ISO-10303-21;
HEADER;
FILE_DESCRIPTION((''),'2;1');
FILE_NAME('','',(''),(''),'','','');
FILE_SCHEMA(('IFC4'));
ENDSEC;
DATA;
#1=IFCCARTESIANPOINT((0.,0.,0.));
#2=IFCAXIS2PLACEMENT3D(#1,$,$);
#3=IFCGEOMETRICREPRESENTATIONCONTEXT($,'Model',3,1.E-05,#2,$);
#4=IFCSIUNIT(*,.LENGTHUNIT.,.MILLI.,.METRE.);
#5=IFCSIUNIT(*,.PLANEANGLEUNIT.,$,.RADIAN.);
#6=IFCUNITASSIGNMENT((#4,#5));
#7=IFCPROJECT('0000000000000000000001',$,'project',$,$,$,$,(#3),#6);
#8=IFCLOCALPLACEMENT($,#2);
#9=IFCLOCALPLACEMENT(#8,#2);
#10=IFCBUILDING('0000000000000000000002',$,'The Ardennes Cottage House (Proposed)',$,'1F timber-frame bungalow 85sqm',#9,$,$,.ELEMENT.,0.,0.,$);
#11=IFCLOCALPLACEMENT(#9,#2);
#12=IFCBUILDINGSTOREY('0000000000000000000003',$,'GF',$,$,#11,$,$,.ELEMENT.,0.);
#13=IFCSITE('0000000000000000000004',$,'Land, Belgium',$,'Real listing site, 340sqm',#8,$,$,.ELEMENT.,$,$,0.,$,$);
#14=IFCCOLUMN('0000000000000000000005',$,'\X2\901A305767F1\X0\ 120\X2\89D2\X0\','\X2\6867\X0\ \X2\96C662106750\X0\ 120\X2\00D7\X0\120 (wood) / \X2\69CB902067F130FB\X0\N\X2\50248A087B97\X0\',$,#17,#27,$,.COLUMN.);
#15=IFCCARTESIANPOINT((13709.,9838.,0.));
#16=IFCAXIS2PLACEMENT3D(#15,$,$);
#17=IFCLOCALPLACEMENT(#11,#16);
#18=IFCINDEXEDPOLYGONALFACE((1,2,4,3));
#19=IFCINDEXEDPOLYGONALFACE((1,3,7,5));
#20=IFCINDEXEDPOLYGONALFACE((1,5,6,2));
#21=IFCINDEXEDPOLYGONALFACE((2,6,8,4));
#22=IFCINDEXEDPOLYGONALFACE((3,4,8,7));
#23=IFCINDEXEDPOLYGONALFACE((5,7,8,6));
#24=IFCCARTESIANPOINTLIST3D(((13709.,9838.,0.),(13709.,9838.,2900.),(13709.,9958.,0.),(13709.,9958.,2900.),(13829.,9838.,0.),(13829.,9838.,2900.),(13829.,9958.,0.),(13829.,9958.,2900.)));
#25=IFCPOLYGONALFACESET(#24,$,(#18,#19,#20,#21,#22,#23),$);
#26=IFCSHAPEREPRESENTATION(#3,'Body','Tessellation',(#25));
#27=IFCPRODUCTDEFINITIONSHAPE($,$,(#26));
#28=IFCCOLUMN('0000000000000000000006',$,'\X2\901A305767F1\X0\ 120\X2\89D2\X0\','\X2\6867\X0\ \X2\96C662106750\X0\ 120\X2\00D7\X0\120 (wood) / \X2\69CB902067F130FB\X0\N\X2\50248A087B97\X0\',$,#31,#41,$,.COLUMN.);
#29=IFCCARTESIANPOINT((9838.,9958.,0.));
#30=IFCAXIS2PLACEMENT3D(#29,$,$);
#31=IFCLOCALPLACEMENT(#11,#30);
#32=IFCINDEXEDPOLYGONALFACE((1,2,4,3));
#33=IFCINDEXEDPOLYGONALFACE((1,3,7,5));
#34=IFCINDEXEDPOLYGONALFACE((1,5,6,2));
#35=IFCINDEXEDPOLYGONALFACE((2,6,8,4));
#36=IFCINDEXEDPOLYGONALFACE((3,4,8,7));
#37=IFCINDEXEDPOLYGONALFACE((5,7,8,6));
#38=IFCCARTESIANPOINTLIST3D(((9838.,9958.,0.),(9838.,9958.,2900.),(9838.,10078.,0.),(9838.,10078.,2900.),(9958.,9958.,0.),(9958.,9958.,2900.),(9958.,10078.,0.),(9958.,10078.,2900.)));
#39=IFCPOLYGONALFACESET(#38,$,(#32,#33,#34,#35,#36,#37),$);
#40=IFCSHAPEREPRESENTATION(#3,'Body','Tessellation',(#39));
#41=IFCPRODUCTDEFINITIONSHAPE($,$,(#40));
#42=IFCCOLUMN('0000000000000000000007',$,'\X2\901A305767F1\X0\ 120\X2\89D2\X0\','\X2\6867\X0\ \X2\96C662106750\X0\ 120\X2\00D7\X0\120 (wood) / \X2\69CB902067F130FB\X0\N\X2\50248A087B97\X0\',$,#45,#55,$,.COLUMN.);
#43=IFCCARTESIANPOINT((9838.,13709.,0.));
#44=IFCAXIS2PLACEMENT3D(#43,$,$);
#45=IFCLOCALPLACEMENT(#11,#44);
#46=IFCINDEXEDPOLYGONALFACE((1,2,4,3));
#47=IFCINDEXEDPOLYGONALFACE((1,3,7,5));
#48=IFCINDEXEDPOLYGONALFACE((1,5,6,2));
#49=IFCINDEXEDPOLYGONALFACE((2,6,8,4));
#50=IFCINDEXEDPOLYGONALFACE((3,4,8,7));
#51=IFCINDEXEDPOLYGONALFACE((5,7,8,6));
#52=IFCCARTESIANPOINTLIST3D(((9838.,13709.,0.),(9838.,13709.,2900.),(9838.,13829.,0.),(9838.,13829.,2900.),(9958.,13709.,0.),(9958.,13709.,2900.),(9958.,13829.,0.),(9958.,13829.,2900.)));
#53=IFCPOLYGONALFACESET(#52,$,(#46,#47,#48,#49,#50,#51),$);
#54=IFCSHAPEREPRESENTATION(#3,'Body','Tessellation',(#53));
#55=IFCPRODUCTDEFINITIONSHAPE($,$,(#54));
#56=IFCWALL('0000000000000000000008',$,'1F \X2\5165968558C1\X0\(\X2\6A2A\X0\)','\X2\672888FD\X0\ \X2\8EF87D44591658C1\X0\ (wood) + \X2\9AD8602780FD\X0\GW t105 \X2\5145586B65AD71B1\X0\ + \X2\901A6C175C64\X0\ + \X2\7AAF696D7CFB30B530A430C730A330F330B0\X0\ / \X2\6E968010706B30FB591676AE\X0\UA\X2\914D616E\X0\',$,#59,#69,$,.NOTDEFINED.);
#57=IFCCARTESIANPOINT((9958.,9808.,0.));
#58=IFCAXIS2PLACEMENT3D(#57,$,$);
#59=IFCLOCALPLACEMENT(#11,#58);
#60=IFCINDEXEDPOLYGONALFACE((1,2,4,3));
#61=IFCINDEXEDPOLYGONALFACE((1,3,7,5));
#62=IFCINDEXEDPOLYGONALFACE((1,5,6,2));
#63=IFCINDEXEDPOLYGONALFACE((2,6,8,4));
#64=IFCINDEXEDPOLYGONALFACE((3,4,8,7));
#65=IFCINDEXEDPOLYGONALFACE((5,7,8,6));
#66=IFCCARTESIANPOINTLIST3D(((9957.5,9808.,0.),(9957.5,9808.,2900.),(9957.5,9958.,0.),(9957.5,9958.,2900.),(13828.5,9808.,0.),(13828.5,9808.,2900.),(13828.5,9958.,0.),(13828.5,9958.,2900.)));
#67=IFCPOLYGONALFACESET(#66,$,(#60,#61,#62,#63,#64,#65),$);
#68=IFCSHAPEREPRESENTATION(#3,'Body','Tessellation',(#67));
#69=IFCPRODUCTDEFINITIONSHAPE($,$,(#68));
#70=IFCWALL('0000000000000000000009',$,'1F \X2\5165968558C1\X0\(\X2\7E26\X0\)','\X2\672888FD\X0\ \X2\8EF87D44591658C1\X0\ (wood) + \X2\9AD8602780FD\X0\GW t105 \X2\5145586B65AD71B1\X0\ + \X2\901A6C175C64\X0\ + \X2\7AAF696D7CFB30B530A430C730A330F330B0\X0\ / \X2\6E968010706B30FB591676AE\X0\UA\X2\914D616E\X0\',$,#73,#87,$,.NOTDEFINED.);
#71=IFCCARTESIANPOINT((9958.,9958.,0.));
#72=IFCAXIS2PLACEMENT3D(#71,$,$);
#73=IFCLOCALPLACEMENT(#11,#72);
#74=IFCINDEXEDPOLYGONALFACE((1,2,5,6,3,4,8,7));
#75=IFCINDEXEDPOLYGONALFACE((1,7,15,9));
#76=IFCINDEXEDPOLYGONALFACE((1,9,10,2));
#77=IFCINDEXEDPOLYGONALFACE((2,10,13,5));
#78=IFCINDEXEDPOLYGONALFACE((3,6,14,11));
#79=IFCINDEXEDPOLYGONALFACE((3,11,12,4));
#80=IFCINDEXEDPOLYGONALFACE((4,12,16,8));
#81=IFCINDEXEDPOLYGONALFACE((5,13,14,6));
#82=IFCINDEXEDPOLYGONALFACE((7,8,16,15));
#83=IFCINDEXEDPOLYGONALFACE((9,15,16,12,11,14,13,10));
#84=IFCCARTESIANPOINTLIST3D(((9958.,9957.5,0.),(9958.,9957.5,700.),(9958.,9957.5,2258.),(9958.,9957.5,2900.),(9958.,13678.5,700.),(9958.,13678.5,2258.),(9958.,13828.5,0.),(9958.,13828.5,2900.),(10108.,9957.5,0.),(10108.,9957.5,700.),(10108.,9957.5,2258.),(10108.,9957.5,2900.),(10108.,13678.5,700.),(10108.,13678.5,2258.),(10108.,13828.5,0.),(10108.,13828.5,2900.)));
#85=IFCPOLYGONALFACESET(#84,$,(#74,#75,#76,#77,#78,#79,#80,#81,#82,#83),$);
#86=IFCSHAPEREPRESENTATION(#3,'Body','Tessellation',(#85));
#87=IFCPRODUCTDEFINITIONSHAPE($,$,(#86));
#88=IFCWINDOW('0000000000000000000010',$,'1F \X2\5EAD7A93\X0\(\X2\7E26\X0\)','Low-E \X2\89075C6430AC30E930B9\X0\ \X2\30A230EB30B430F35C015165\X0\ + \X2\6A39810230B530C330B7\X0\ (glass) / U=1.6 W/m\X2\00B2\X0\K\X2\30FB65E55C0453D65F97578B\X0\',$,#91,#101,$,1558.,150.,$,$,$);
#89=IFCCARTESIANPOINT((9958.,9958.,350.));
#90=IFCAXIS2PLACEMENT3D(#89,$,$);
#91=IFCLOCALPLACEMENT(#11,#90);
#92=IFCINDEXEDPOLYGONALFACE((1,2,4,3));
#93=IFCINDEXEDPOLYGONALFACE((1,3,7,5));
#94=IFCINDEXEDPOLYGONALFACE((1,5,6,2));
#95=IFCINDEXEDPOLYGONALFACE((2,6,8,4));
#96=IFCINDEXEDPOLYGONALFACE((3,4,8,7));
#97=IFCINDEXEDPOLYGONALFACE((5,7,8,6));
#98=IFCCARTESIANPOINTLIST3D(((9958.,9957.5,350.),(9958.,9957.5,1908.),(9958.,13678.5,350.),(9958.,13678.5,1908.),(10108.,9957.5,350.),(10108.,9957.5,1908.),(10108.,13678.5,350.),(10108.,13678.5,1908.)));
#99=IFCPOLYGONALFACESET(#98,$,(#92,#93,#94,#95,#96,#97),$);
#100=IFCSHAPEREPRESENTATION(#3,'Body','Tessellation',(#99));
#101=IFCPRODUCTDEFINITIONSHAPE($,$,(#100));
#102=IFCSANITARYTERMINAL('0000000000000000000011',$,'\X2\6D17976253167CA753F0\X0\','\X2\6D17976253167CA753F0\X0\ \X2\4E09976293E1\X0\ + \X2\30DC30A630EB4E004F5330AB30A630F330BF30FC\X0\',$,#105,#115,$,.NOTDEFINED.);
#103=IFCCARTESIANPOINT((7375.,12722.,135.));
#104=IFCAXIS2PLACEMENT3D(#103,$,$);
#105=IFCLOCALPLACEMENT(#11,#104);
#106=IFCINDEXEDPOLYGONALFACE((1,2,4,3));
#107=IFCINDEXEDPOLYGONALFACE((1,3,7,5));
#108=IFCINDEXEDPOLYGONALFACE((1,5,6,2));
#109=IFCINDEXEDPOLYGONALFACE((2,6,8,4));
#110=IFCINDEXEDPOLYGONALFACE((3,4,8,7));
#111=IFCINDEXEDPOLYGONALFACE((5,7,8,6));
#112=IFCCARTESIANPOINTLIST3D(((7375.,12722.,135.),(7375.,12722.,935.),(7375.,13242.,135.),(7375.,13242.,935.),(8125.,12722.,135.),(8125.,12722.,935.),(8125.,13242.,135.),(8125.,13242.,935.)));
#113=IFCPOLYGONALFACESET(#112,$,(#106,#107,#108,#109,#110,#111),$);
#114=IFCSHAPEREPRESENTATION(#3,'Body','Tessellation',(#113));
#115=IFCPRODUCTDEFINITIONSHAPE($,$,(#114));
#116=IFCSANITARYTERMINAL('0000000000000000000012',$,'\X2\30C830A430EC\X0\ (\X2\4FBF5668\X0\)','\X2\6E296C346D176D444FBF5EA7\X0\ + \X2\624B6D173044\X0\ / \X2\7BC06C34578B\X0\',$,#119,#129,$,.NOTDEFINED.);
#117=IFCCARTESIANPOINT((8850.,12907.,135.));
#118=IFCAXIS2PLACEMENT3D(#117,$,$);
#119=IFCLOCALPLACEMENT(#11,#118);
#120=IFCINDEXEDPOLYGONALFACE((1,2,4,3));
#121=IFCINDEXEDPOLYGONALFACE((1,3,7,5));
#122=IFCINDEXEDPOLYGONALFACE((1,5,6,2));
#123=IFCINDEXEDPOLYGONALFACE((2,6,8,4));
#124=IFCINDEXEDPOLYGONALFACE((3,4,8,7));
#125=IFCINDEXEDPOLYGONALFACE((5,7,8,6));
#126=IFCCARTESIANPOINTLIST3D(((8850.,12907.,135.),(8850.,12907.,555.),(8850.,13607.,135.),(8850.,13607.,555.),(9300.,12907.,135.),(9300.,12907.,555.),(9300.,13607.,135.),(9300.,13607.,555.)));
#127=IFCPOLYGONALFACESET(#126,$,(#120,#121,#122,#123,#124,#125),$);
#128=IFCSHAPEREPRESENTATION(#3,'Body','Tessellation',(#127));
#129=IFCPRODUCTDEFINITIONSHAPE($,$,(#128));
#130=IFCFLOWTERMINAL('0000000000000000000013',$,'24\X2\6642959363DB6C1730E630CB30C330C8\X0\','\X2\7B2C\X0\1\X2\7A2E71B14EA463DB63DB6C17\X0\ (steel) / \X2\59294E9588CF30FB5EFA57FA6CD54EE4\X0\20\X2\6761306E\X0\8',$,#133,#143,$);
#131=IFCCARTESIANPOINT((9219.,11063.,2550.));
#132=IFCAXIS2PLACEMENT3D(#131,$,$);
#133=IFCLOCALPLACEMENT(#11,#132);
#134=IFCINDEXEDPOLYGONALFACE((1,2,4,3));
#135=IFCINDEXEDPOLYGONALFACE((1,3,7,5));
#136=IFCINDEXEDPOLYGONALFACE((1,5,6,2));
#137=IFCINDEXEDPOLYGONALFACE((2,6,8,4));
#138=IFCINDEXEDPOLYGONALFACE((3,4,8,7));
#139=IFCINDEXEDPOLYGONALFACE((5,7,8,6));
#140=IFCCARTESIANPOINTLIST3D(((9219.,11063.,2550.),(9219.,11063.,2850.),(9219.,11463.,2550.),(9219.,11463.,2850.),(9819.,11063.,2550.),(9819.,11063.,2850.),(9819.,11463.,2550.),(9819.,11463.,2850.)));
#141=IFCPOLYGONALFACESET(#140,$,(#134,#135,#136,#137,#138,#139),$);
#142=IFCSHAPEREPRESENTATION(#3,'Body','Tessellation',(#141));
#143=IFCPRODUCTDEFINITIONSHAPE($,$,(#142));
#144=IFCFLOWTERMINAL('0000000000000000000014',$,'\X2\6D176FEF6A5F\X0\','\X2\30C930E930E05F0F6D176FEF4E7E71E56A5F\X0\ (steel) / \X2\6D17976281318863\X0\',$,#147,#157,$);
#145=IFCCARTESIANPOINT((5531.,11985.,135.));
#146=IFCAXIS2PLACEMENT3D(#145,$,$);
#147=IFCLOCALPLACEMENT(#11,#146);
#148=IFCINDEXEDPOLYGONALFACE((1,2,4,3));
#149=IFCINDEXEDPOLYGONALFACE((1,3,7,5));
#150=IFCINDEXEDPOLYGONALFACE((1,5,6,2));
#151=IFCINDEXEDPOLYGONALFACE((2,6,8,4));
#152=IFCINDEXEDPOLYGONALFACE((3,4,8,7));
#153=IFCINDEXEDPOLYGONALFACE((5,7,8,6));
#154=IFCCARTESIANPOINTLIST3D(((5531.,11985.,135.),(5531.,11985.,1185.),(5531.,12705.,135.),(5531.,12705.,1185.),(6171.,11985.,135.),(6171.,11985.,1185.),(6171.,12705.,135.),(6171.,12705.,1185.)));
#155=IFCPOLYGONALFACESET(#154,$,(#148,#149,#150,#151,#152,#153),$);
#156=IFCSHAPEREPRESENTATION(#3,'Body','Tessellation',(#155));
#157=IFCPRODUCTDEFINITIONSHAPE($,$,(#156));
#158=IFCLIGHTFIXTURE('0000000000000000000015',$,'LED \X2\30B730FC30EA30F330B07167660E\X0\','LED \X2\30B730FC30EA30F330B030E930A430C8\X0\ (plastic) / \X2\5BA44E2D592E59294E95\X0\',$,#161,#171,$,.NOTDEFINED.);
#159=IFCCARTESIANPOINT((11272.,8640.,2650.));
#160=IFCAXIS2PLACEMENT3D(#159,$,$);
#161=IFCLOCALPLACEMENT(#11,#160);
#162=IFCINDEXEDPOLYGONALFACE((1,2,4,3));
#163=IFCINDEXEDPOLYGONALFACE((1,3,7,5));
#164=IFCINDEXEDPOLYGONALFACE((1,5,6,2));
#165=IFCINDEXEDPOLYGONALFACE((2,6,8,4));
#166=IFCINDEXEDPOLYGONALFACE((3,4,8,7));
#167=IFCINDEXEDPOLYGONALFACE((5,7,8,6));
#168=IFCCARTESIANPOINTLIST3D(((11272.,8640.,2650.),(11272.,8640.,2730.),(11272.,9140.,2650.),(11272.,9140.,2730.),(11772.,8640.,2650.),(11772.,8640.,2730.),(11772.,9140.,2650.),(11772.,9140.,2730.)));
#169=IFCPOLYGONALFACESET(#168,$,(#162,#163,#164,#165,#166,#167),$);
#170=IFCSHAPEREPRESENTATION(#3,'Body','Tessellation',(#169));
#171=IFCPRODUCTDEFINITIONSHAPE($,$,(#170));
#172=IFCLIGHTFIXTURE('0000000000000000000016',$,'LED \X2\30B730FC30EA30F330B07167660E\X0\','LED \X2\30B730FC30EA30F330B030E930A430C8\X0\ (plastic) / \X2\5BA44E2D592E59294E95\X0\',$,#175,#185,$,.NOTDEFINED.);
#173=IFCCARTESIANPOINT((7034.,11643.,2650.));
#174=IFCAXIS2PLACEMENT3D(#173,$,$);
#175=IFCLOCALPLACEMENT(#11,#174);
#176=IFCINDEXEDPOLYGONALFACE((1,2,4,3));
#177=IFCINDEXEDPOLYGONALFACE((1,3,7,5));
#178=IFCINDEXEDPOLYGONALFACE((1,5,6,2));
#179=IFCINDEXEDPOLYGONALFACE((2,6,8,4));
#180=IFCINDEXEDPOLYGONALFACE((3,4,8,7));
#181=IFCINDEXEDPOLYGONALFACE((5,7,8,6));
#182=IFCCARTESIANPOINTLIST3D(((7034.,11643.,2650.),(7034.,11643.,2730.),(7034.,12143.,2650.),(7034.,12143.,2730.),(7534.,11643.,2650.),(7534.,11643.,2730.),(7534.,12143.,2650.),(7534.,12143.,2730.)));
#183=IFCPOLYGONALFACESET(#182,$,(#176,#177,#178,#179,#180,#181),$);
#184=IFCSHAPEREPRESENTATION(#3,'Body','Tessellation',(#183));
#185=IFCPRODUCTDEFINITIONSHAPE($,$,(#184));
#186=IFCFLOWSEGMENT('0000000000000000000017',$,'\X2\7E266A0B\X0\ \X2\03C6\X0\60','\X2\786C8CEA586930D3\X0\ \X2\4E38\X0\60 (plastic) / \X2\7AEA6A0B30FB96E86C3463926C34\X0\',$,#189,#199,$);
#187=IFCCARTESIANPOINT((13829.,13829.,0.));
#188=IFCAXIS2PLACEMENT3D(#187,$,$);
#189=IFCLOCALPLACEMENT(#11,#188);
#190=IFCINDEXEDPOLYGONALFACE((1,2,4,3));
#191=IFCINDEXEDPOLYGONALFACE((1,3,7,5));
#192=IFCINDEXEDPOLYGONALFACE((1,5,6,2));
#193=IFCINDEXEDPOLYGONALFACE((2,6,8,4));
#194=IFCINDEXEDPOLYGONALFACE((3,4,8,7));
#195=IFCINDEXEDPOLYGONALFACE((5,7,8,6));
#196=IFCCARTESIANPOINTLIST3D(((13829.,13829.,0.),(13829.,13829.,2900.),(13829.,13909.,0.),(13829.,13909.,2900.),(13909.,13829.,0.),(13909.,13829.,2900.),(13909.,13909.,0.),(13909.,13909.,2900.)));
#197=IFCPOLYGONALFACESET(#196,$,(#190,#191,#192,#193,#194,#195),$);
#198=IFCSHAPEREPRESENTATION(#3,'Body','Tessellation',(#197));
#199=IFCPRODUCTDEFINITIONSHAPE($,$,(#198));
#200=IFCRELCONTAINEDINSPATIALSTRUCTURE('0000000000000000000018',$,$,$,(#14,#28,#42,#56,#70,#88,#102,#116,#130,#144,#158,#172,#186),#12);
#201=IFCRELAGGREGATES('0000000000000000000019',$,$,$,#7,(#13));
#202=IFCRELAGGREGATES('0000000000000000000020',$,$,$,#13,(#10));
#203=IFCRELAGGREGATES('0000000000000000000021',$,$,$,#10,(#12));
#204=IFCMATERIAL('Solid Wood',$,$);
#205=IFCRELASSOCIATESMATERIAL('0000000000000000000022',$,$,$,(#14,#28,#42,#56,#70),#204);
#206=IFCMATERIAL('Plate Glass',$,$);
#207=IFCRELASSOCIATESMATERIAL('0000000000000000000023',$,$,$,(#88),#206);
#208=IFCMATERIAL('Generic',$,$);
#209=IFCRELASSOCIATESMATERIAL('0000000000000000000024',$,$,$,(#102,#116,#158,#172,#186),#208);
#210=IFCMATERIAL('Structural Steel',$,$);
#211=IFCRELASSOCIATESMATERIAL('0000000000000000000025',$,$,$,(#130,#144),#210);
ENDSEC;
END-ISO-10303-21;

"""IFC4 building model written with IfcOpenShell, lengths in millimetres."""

from ifc_helpers import new_model, si_unit, frame, frame_2d, origin, place, context, project, spatial, rectangle, extrude, material, element, fill, save


model = new_model("IFC4")

# Units and contexts
model_context = context("Model", 3, precision=1e-05, world=origin())
ifc_project = project(units=[si_unit("LENGTHUNIT", "METRE", prefix="MILLI"), si_unit("PLANEANGLEUNIT", "RADIAN")], contexts=[model_context])

# Site, building, storey
site_placement = place(None, origin())
site = spatial("IfcSite", under=ifc_project, at=site_placement, Name="Land, Belgium", ObjectType="Real listing site, 340sqm", CompositionType="ELEMENT", RefElevation=0.0)
building_placement = place(site_placement, origin())
building = spatial("IfcBuilding", under=site, at=building_placement, Name="The Ardennes Cottage House (Proposed)", ObjectType="1F timber-frame bungalow 85sqm", CompositionType="ELEMENT", ElevationOfRefHeight=0.0, ElevationOfTerrain=0.0)
storey_placement = place(building_placement, origin())
storey = spatial("IfcBuildingStorey", under=building, at=storey_placement, Name="GF", CompositionType="ELEMENT", Elevation=0.0)

# Columns
ifc_material_1 = material(Name="Solid Wood")
column_1_placement = place(storey_placement, frame((13709.0, 9838.0, 0.0)))
element("IfcColumn", 1, at=column_1_placement, inside=storey, material=ifc_material_1, Name="通し柱 120角", Description="桧 集成材 120×120 (wood) / 構造柱・N値計算", PredefinedType="COLUMN", context=model_context, shape_type="SweptSolid", body=[
    extrude(rectangle(XDim=120.0, YDim=120.0, at=frame_2d((60.0, 60.0))), frame((13709.0, 9838.0, 0.0)), (0.0, 0.0, 1.0), 2900.0),
])
column_2_placement = place(storey_placement, frame((9838.0, 9958.0, 0.0)))
element("IfcColumn", 2, at=column_2_placement, inside=storey, material=ifc_material_1, Name="通し柱 120角", Description="桧 集成材 120×120 (wood) / 構造柱・N値計算", PredefinedType="COLUMN", context=model_context, shape_type="SweptSolid", body=[
    extrude(rectangle(XDim=120.0, YDim=120.0, at=frame_2d((60.0, 60.0))), frame((9838.0, 9958.0, 0.0)), (0.0, 0.0, 1.0), 2900.0),
])
column_3_placement = place(storey_placement, frame((9838.0, 13709.0, 0.0)))
element("IfcColumn", 3, at=column_3_placement, inside=storey, material=ifc_material_1, Name="通し柱 120角", Description="桧 集成材 120×120 (wood) / 構造柱・N値計算", PredefinedType="COLUMN", context=model_context, shape_type="SweptSolid", body=[
    extrude(rectangle(XDim=120.0, YDim=120.0, at=frame_2d((60.0, 60.0))), frame((9838.0, 13709.0, 0.0)), (0.0, 0.0, 1.0), 2900.0),
])

# Wall
wall_1_placement = place(storey_placement, frame((9958.0, 9808.0, 0.0)))
element("IfcWall", 4, at=wall_1_placement, inside=storey, material=ifc_material_1, Name="1F 入隅壁(横)", Description="木製 軸組外壁 (wood) + 高性能GW t105 充填断熱 + 通気層 + 窯業系サイディング / 準耐火・外皮UA配慮", PredefinedType="NOTDEFINED", context=model_context, shape_type="SweptSolid", body=[
    extrude(rectangle(XDim=3871.0, YDim=150.0, at=frame_2d((1935.0, 75.0))), frame((9958.0, 9808.0, 0.0)), (0.0, 0.0, 1.0), 2900.0),
])

# Wall, opening, window
wall_2_placement = place(storey_placement, frame((9958.0, 9958.0, 0.0)))
wall_2 = element("IfcWall", 5, at=wall_2_placement, inside=storey, material=ifc_material_1, Name="1F 入隅壁(縦)", Description="木製 軸組外壁 (wood) + 高性能GW t105 充填断熱 + 通気層 + 窯業系サイディング / 準耐火・外皮UA配慮", PredefinedType="NOTDEFINED", context=model_context, shape_type="SweptSolid", body=[
    extrude(rectangle(XDim=150.0, YDim=3871.0, at=frame_2d((75.0, 1935.0))), frame((9958.0, 9958.0, 0.0)), (0.0, 0.0, 1.0), 2900.0),
])
opening_placement = place(storey_placement, frame((9958.0, 9958.0, 350.0)))
opening = element("IfcOpeningElement", 6, at=opening_placement, cuts=wall_2, PredefinedType="NOTDEFINED", context=model_context, shape_type="SweptSolid", body=[
    extrude(rectangle(XDim=150.0, YDim=3721.0, at=frame_2d((75.0, 1860.0))), frame((9958.0, 9958.0, 350.0)), (0.0, 0.0, 1.0), 1558.0),
])
ifc_material_2 = material(Name="Plate Glass")
window_placement = place(storey_placement, frame((9958.0, 9958.0, 350.0)))
window = element("IfcWindow", 7, at=window_placement, inside=storey, material=ifc_material_2, Name="1F 庭窓(縦)", Description="Low-E 複層ガラス アルゴン封入 + 樹脂サッシ (glass) / U=1.6 W/m²K・日射取得型", OverallHeight=1558.0, OverallWidth=150.0, context=model_context, shape_type="SweptSolid", body=[
    extrude(rectangle(XDim=150.0, YDim=3721.0, at=frame_2d((75.0, 1860.0))), frame((9958.0, 9958.0, 350.0)), (0.0, 0.0, 1.0), 1558.0),
])
fill(opening, window)

# Sanitary terminals
ifc_material_3 = material(Name="Generic")
sanitary_terminal_1_placement = place(storey_placement, frame((7375.0, 12722.0, 135.0)))
element("IfcSanitaryTerminal", 8, at=sanitary_terminal_1_placement, inside=storey, material=ifc_material_3, Name="洗面化粧台", Description="洗面化粧台 三面鏡 + ボウル一体カウンター", PredefinedType="NOTDEFINED", context=model_context, shape_type="SweptSolid", body=[
    extrude(rectangle(XDim=750.0, YDim=520.0, at=frame_2d((375.0, 260.0))), frame((7375.0, 12722.0, 135.0)), (0.0, 0.0, 1.0), 800.0),
])
sanitary_terminal_2_placement = place(storey_placement, frame((8850.0, 12907.0, 135.0)))
element("IfcSanitaryTerminal", 9, at=sanitary_terminal_2_placement, inside=storey, material=ifc_material_3, Name="トイレ (便器)", Description="温水洗浄便座 + 手洗い / 節水型", PredefinedType="NOTDEFINED", context=model_context, shape_type="SweptSolid", body=[
    extrude(rectangle(XDim=450.0, YDim=700.0, at=frame_2d((225.0, 350.0))), frame((8850.0, 12907.0, 135.0)), (0.0, 0.0, 1.0), 420.0),
])

# Flow terminals
ifc_material_4 = material(Name="Structural Steel")
flow_terminal_1_placement = place(storey_placement, frame((9219.0, 11063.0, 2550.0)))
element("IfcFlowTerminal", 10, at=flow_terminal_1_placement, inside=storey, material=ifc_material_4, Name="24時間換気ユニット", Description="第1種熱交換換気 (steel) / 天井裏・建基法令20条の8", context=model_context, shape_type="SweptSolid", body=[
    extrude(rectangle(XDim=600.0, YDim=400.0, at=frame_2d((300.0, 200.0))), frame((9219.0, 11063.0, 2550.0)), (0.0, 0.0, 1.0), 300.0),
])
flow_terminal_2_placement = place(storey_placement, frame((5531.0, 11985.0, 135.0)))
element("IfcFlowTerminal", 11, at=flow_terminal_2_placement, inside=storey, material=ifc_material_4, Name="洗濯機", Description="ドラム式洗濯乾燥機 (steel) / 洗面脱衣", context=model_context, shape_type="SweptSolid", body=[
    extrude(rectangle(XDim=640.0, YDim=720.0, at=frame_2d((320.0, 360.0))), frame((5531.0, 11985.0, 135.0)), (0.0, 0.0, 1.0), 1050.0),
])

# Light fixtures
light_fixture_1_placement = place(storey_placement, frame((11272.0, 8640.0, 2650.0)))
element("IfcLightFixture", 12, at=light_fixture_1_placement, inside=storey, material=ifc_material_3, Name="LED シーリング照明", Description="LED シーリングライト (plastic) / 室中央天井", PredefinedType="NOTDEFINED", context=model_context, shape_type="SweptSolid", body=[
    extrude(rectangle(XDim=500.0, YDim=500.0, at=frame_2d((250.0, 250.0))), frame((11272.0, 8640.0, 2650.0)), (0.0, 0.0, 1.0), 80.0),
])
light_fixture_2_placement = place(storey_placement, frame((7034.0, 11643.0, 2650.0)))
element("IfcLightFixture", 13, at=light_fixture_2_placement, inside=storey, material=ifc_material_3, Name="LED シーリング照明", Description="LED シーリングライト (plastic) / 室中央天井", PredefinedType="NOTDEFINED", context=model_context, shape_type="SweptSolid", body=[
    extrude(rectangle(XDim=500.0, YDim=500.0, at=frame_2d((250.0, 250.0))), frame((7034.0, 11643.0, 2650.0)), (0.0, 0.0, 1.0), 80.0),
])

# Flow segment
flow_segment_placement = place(storey_placement, frame((13829.0, 13829.0, 0.0)))
element("IfcFlowSegment", 14, at=flow_segment_placement, inside=storey, material=ifc_material_3, Name="縦樋 φ60", Description="硬質塩ビ 丸60 (plastic) / 竪樋・雨水排水", context=model_context, shape_type="SweptSolid", body=[
    extrude(rectangle(XDim=80.0, YDim=80.0, at=frame_2d((40.0, 40.0))), frame((13829.0, 13829.0, 0.0)), (0.0, 0.0, 1.0), 2900.0),
])

save(model, "model.ifc")
